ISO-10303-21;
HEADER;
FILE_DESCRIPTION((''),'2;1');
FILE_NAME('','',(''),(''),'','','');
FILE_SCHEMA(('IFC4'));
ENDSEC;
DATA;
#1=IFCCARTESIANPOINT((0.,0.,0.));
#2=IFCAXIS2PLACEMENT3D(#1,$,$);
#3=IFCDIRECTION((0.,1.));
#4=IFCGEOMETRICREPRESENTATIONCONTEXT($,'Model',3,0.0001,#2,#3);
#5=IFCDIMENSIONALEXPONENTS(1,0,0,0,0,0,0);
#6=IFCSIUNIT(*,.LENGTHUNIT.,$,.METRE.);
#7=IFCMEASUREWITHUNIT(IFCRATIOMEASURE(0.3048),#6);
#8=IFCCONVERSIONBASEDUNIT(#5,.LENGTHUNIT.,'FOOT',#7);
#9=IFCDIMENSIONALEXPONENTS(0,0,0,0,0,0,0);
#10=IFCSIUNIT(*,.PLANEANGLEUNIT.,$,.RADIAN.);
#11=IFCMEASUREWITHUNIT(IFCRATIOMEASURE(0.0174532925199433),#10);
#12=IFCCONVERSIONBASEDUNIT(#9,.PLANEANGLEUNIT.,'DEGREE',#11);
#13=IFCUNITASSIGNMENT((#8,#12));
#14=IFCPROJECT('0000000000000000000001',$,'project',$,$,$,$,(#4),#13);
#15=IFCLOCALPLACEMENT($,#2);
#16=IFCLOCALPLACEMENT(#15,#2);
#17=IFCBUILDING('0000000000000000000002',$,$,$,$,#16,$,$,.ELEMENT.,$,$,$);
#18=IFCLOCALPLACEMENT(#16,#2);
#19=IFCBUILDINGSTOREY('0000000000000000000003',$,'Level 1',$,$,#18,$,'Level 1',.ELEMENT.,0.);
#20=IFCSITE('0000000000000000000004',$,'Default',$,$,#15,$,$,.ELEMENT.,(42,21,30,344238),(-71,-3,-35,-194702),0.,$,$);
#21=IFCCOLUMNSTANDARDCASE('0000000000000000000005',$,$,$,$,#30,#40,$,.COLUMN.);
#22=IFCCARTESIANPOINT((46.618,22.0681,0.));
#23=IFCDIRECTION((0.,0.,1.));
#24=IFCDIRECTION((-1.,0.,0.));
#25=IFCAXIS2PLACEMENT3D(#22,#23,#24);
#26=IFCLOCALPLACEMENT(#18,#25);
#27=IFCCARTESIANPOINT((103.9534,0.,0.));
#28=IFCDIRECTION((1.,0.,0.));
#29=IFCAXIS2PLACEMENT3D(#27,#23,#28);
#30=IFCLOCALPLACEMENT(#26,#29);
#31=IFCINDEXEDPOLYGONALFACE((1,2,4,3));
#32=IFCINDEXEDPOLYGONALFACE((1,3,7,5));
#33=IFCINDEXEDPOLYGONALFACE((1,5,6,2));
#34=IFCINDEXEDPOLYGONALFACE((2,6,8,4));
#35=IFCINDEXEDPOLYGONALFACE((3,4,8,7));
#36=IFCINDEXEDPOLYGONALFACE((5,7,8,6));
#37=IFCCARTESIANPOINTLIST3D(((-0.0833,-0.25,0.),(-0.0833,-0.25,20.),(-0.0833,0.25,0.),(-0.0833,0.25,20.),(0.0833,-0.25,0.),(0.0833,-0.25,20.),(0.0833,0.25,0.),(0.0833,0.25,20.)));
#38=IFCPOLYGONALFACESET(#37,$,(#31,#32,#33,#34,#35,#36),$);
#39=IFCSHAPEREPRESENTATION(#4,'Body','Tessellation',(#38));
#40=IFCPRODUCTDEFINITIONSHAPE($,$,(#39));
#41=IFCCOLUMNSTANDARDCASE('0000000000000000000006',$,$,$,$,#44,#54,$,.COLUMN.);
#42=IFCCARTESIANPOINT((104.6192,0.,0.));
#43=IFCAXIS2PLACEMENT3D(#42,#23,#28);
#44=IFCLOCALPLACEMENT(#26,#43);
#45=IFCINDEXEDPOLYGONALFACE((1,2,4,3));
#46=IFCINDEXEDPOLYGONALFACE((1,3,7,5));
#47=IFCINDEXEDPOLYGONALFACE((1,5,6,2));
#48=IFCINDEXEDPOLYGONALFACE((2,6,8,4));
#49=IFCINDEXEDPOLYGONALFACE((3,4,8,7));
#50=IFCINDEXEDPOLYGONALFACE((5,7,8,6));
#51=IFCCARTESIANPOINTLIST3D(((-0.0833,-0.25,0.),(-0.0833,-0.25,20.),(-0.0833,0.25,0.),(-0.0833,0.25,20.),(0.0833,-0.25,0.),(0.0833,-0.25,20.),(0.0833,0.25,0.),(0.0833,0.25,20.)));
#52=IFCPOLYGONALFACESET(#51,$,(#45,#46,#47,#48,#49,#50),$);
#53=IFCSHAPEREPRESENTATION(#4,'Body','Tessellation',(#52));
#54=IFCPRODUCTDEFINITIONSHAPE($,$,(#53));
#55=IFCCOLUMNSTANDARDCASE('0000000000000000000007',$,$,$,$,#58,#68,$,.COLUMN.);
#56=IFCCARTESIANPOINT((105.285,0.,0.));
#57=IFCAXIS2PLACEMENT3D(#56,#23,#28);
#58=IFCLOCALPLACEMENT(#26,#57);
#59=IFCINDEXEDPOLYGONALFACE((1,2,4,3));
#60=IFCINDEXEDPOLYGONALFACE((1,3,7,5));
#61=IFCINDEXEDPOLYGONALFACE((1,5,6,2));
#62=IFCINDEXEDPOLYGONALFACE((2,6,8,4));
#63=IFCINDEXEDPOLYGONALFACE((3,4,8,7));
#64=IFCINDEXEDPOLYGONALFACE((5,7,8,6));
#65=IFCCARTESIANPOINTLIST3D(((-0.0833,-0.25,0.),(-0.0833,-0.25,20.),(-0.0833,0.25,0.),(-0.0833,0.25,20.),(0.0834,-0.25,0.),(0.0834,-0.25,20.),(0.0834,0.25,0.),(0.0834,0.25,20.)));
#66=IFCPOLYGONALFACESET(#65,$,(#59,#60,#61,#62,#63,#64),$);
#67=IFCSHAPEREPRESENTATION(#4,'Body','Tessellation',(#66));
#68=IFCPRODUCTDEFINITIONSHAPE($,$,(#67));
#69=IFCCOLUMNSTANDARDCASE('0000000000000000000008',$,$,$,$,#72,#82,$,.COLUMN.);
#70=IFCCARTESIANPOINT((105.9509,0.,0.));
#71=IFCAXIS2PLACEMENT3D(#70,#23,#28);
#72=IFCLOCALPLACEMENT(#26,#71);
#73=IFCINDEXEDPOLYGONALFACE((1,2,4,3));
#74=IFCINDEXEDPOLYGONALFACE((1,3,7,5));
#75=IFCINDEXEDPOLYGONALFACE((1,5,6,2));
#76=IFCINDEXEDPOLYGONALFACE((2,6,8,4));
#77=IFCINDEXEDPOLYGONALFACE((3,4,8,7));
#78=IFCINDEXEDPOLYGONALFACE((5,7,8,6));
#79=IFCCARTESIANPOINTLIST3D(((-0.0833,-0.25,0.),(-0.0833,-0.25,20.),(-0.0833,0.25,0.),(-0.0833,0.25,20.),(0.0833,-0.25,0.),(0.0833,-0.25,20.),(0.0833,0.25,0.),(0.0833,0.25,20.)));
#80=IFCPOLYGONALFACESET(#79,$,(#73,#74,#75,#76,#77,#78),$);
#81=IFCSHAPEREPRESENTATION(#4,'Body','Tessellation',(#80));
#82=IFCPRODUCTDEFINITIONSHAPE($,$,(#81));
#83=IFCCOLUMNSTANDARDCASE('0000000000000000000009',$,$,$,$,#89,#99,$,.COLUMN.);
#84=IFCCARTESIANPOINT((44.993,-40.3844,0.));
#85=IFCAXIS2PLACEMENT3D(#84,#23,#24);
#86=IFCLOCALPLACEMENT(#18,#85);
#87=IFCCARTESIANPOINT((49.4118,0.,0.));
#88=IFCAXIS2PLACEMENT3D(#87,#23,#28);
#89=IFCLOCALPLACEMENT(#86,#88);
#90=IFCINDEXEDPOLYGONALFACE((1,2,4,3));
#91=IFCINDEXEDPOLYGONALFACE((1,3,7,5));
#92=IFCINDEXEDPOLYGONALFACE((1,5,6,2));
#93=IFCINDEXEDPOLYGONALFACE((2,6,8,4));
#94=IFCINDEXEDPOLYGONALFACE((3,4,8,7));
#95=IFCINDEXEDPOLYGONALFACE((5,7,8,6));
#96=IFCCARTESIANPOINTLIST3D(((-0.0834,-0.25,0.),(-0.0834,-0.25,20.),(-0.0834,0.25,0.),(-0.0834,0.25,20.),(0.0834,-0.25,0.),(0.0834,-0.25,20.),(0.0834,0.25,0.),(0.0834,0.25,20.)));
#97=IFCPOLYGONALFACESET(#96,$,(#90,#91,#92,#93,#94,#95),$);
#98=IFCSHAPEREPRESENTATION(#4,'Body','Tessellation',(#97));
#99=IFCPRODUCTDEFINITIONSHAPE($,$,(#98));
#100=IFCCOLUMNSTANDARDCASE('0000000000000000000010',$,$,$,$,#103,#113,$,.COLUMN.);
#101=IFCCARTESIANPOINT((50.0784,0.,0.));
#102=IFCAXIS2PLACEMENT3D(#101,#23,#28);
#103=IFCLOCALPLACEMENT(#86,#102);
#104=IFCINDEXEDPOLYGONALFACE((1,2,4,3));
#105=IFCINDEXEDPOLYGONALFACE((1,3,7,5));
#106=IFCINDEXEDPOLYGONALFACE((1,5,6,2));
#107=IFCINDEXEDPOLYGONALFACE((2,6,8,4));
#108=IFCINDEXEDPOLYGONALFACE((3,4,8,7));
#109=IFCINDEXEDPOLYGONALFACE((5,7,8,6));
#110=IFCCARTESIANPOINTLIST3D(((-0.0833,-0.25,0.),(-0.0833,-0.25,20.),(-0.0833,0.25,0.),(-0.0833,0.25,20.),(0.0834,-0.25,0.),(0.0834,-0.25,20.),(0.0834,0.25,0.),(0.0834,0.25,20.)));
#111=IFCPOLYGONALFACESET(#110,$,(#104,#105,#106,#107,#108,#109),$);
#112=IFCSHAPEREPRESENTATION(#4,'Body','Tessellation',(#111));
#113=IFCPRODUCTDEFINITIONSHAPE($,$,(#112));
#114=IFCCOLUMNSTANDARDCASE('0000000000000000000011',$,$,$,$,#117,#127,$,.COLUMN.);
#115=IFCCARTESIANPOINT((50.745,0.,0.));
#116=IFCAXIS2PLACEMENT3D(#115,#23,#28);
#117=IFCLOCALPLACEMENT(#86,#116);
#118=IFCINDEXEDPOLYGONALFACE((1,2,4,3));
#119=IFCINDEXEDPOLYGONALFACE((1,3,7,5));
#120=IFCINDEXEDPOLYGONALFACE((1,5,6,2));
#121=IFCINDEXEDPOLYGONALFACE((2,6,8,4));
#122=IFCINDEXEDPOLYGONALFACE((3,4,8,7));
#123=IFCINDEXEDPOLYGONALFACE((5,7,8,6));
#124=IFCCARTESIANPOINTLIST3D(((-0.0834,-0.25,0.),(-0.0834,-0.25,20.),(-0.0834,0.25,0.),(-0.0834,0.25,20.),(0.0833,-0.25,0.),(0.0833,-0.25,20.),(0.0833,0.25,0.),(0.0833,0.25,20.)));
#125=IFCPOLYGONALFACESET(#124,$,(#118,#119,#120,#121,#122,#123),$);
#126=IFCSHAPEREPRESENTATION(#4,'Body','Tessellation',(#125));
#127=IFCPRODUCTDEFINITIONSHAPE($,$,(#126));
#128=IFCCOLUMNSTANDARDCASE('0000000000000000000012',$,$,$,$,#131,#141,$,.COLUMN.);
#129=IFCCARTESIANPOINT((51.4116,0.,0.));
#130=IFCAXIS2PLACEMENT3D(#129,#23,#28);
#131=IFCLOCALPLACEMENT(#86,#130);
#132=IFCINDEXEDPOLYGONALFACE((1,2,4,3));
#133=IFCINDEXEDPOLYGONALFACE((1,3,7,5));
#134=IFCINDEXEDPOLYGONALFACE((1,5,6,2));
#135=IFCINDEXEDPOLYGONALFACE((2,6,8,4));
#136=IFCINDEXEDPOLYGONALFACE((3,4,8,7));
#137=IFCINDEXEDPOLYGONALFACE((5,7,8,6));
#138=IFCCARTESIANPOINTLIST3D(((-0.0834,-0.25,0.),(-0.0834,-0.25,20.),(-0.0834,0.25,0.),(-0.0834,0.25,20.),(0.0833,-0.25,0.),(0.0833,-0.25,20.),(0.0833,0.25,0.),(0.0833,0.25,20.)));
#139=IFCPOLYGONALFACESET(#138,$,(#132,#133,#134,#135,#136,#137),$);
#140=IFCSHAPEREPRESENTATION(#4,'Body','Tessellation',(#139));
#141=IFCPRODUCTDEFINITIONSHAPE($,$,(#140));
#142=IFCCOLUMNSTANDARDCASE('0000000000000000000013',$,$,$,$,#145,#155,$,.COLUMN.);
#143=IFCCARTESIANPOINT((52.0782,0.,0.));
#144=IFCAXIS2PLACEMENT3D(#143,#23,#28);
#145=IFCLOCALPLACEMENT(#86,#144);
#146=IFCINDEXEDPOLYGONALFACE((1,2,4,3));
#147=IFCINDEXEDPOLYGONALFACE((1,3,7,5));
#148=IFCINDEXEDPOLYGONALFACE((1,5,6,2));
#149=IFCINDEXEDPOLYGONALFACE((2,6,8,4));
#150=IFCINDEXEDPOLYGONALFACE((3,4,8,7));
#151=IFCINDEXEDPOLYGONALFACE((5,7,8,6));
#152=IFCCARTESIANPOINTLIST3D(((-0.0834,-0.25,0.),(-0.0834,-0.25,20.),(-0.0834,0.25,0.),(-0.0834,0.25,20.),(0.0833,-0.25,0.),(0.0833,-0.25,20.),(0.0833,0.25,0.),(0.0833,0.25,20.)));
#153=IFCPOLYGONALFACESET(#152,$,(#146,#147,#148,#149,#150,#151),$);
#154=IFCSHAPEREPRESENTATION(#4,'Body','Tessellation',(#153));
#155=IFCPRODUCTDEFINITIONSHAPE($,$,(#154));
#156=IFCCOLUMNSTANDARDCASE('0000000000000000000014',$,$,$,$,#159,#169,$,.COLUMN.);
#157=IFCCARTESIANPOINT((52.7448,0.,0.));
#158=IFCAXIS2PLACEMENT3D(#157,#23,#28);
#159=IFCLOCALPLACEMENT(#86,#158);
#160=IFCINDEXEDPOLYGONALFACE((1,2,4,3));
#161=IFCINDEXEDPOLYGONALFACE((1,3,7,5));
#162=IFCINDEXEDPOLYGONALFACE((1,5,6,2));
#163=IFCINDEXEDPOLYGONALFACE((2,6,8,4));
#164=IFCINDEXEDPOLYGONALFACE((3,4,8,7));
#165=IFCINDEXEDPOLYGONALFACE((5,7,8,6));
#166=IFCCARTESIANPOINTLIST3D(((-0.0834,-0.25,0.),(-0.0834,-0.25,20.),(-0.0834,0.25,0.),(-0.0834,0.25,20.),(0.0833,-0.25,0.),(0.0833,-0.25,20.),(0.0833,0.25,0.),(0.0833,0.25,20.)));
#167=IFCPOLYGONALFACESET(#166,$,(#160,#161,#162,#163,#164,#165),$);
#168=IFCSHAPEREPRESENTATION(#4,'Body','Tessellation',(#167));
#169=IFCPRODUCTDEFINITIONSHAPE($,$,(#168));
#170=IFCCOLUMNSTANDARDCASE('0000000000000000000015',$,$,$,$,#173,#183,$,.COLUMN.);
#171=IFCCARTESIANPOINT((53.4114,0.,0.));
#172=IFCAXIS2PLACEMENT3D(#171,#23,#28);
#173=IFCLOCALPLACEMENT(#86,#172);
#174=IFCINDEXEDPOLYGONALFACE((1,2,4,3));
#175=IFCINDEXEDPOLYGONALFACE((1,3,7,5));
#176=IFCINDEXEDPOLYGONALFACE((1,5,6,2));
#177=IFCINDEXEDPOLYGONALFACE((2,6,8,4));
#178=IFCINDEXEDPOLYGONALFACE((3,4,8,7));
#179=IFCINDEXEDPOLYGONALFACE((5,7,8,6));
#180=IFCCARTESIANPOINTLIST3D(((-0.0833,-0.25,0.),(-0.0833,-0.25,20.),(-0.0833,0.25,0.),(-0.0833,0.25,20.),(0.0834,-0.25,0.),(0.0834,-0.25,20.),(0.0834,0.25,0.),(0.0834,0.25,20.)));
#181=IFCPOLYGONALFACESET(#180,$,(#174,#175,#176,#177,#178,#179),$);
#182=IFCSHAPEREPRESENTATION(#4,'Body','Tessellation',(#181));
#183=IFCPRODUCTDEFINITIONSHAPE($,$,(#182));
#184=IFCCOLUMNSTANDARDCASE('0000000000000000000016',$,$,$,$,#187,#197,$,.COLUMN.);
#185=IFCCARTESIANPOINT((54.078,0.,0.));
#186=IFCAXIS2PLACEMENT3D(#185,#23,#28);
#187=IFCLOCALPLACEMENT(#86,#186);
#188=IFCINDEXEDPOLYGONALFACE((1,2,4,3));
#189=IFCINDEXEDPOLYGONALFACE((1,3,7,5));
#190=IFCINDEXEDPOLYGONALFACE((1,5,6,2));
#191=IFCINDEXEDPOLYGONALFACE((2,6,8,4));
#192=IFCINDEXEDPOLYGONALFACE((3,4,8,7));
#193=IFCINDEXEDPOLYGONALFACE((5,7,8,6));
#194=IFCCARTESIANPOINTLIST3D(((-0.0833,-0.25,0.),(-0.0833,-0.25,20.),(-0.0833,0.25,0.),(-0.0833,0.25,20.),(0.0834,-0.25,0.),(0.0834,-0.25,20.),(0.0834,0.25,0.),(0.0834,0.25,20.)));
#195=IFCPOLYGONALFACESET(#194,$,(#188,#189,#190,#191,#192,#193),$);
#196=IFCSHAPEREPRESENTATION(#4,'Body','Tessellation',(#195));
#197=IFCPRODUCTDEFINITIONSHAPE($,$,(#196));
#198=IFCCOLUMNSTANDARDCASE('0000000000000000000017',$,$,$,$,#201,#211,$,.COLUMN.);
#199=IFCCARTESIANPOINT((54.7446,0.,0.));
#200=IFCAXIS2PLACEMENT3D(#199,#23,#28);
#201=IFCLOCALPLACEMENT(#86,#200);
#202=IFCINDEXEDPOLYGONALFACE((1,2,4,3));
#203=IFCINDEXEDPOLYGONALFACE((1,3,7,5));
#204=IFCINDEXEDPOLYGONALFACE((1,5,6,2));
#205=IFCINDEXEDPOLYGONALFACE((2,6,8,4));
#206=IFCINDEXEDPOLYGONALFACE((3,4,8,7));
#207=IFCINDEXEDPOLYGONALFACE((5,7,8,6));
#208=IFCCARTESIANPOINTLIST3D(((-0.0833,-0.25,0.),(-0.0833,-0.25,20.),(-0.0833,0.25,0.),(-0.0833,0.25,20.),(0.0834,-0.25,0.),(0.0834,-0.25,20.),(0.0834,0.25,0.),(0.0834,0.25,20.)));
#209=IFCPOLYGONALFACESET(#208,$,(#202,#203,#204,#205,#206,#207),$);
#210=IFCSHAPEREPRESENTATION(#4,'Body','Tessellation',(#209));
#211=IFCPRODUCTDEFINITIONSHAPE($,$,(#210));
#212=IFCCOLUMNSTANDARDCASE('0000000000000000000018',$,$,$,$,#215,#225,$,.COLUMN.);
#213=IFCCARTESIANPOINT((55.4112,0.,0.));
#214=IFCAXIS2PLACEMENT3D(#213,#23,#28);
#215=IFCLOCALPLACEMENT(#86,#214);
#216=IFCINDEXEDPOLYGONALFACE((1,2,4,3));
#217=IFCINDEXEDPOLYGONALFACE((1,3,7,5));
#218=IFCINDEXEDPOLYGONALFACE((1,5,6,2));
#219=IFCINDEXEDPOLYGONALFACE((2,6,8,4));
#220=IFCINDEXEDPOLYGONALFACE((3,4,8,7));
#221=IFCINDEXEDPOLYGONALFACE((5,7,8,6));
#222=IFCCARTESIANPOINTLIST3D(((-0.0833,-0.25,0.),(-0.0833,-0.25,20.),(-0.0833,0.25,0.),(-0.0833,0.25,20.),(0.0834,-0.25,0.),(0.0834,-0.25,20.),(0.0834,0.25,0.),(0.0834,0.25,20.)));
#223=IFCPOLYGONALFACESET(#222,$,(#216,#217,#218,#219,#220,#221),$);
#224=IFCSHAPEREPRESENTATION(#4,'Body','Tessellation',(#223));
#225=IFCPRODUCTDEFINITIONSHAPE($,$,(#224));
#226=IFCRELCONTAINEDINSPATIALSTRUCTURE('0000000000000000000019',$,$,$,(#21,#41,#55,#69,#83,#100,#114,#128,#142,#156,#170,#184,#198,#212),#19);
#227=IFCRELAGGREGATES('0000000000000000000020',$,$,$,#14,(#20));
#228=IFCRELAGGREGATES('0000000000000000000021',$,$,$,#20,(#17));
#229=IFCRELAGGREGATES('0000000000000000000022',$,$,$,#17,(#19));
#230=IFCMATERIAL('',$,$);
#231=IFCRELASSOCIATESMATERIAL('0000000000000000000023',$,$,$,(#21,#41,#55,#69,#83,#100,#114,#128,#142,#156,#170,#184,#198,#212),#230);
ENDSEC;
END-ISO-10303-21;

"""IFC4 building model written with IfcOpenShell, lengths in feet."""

from ifc_helpers import new_model, entity, si_unit, converted_unit, direction, frame, origin, place, context, project, spatial, rectangle, extrude, material, element, save


model = new_model("IFC4")

# Units and contexts
model_context = context("Model", 3, precision=0.0001, world=origin(), true_north=direction((0.0, 1.0)))
ifc_project = project(units=[converted_unit("LENGTHUNIT", "FOOT", entity("IfcRatioMeasure", 0.3048), si_unit("LENGTHUNIT", "METRE"), dimensions=[1, 0, 0, 0, 0, 0, 0]), converted_unit("PLANEANGLEUNIT", "DEGREE", entity("IfcRatioMeasure", 0.0174532925199433), si_unit("PLANEANGLEUNIT", "RADIAN"), dimensions=[0, 0, 0, 0, 0, 0, 0])], contexts=[model_context])

# Site, building, storey
site_placement = place(None, origin())
site = spatial("IfcSite", under=ifc_project, at=site_placement, Name="Default", CompositionType="ELEMENT", RefLatitude=(42, 21, 30, 344238), RefLongitude=(-71, -3, -35, -194702), RefElevation=0.0)
building_placement = place(site_placement, origin())
building = spatial("IfcBuilding", under=site, at=building_placement, CompositionType="ELEMENT")
storey_placement = place(building_placement, origin())
storey = spatial("IfcBuildingStorey", under=building, at=storey_placement, Name="Level 1", LongName="Level 1", CompositionType="ELEMENT", Elevation=0.0)

# Columns
ifc_material = material(Name="")
placement_1 = place(storey_placement, frame((46.618, 22.0681, 0.0), z_axis=(0.0, 0.0, 1.0), x_axis=(-1.0, 0.0, 0.0)))
for number, where, z_axis, x_axis in (
    (1, (103.9534, 0.0, 0.0), (0.0, 0.0, 1.0), (1.0, 0.0, 0.0)),
    (2, (104.6192, 0.0, 0.0), (0.0, 0.0, 1.0), (1.0, 0.0, 0.0)),
    (3, (105.285, 0.0, 0.0), (0.0, 0.0, 1.0), (1.0, 0.0, 0.0)),
    (4, (105.9509, 0.0, 0.0), (0.0, 0.0, 1.0), (1.0, 0.0, 0.0)),
):
    element("IfcColumnStandardCase", number, at=place(placement_1, frame(where, z_axis=z_axis, x_axis=x_axis)), inside=storey, material=ifc_material, PredefinedType="COLUMN", context=model_context, shape_type="SweptSolid", body=[
        extrude(rectangle(XDim=0.1667, YDim=0.5), origin(), (0.0, 0.0, 1.0), 20.0),
    ])
placement_2 = place(storey_placement, frame((44.993, -40.3844, 0.0), z_axis=(0.0, 0.0, 1.0), x_axis=(-1.0, 0.0, 0.0)))
for number, where, z_axis, x_axis in (
    (5, (49.4118, 0.0, 0.0), (0.0, 0.0, 1.0), (1.0, 0.0, 0.0)),
    (6, (50.0784, 0.0, 0.0), (0.0, 0.0, 1.0), (1.0, 0.0, 0.0)),
    (7, (50.745, 0.0, 0.0), (0.0, 0.0, 1.0), (1.0, 0.0, 0.0)),
    (8, (51.4116, 0.0, 0.0), (0.0, 0.0, 1.0), (1.0, 0.0, 0.0)),
    (9, (52.0782, 0.0, 0.0), (0.0, 0.0, 1.0), (1.0, 0.0, 0.0)),
    (10, (52.7448, 0.0, 0.0), (0.0, 0.0, 1.0), (1.0, 0.0, 0.0)),
    (11, (53.4114, 0.0, 0.0), (0.0, 0.0, 1.0), (1.0, 0.0, 0.0)),
    (12, (54.078, 0.0, 0.0), (0.0, 0.0, 1.0), (1.0, 0.0, 0.0)),
    (13, (54.7446, 0.0, 0.0), (0.0, 0.0, 1.0), (1.0, 0.0, 0.0)),
    (14, (55.4112, 0.0, 0.0), (0.0, 0.0, 1.0), (1.0, 0.0, 0.0)),
):
    element("IfcColumnStandardCase", number, at=place(placement_2, frame(where, z_axis=z_axis, x_axis=x_axis)), inside=storey, material=ifc_material, PredefinedType="COLUMN", context=model_context, shape_type="SweptSolid", body=[
        extrude(rectangle(XDim=0.1667, YDim=0.5), origin(), (0.0, 0.0, 1.0), 20.0),
    ])

save(model, "model.ifc")
